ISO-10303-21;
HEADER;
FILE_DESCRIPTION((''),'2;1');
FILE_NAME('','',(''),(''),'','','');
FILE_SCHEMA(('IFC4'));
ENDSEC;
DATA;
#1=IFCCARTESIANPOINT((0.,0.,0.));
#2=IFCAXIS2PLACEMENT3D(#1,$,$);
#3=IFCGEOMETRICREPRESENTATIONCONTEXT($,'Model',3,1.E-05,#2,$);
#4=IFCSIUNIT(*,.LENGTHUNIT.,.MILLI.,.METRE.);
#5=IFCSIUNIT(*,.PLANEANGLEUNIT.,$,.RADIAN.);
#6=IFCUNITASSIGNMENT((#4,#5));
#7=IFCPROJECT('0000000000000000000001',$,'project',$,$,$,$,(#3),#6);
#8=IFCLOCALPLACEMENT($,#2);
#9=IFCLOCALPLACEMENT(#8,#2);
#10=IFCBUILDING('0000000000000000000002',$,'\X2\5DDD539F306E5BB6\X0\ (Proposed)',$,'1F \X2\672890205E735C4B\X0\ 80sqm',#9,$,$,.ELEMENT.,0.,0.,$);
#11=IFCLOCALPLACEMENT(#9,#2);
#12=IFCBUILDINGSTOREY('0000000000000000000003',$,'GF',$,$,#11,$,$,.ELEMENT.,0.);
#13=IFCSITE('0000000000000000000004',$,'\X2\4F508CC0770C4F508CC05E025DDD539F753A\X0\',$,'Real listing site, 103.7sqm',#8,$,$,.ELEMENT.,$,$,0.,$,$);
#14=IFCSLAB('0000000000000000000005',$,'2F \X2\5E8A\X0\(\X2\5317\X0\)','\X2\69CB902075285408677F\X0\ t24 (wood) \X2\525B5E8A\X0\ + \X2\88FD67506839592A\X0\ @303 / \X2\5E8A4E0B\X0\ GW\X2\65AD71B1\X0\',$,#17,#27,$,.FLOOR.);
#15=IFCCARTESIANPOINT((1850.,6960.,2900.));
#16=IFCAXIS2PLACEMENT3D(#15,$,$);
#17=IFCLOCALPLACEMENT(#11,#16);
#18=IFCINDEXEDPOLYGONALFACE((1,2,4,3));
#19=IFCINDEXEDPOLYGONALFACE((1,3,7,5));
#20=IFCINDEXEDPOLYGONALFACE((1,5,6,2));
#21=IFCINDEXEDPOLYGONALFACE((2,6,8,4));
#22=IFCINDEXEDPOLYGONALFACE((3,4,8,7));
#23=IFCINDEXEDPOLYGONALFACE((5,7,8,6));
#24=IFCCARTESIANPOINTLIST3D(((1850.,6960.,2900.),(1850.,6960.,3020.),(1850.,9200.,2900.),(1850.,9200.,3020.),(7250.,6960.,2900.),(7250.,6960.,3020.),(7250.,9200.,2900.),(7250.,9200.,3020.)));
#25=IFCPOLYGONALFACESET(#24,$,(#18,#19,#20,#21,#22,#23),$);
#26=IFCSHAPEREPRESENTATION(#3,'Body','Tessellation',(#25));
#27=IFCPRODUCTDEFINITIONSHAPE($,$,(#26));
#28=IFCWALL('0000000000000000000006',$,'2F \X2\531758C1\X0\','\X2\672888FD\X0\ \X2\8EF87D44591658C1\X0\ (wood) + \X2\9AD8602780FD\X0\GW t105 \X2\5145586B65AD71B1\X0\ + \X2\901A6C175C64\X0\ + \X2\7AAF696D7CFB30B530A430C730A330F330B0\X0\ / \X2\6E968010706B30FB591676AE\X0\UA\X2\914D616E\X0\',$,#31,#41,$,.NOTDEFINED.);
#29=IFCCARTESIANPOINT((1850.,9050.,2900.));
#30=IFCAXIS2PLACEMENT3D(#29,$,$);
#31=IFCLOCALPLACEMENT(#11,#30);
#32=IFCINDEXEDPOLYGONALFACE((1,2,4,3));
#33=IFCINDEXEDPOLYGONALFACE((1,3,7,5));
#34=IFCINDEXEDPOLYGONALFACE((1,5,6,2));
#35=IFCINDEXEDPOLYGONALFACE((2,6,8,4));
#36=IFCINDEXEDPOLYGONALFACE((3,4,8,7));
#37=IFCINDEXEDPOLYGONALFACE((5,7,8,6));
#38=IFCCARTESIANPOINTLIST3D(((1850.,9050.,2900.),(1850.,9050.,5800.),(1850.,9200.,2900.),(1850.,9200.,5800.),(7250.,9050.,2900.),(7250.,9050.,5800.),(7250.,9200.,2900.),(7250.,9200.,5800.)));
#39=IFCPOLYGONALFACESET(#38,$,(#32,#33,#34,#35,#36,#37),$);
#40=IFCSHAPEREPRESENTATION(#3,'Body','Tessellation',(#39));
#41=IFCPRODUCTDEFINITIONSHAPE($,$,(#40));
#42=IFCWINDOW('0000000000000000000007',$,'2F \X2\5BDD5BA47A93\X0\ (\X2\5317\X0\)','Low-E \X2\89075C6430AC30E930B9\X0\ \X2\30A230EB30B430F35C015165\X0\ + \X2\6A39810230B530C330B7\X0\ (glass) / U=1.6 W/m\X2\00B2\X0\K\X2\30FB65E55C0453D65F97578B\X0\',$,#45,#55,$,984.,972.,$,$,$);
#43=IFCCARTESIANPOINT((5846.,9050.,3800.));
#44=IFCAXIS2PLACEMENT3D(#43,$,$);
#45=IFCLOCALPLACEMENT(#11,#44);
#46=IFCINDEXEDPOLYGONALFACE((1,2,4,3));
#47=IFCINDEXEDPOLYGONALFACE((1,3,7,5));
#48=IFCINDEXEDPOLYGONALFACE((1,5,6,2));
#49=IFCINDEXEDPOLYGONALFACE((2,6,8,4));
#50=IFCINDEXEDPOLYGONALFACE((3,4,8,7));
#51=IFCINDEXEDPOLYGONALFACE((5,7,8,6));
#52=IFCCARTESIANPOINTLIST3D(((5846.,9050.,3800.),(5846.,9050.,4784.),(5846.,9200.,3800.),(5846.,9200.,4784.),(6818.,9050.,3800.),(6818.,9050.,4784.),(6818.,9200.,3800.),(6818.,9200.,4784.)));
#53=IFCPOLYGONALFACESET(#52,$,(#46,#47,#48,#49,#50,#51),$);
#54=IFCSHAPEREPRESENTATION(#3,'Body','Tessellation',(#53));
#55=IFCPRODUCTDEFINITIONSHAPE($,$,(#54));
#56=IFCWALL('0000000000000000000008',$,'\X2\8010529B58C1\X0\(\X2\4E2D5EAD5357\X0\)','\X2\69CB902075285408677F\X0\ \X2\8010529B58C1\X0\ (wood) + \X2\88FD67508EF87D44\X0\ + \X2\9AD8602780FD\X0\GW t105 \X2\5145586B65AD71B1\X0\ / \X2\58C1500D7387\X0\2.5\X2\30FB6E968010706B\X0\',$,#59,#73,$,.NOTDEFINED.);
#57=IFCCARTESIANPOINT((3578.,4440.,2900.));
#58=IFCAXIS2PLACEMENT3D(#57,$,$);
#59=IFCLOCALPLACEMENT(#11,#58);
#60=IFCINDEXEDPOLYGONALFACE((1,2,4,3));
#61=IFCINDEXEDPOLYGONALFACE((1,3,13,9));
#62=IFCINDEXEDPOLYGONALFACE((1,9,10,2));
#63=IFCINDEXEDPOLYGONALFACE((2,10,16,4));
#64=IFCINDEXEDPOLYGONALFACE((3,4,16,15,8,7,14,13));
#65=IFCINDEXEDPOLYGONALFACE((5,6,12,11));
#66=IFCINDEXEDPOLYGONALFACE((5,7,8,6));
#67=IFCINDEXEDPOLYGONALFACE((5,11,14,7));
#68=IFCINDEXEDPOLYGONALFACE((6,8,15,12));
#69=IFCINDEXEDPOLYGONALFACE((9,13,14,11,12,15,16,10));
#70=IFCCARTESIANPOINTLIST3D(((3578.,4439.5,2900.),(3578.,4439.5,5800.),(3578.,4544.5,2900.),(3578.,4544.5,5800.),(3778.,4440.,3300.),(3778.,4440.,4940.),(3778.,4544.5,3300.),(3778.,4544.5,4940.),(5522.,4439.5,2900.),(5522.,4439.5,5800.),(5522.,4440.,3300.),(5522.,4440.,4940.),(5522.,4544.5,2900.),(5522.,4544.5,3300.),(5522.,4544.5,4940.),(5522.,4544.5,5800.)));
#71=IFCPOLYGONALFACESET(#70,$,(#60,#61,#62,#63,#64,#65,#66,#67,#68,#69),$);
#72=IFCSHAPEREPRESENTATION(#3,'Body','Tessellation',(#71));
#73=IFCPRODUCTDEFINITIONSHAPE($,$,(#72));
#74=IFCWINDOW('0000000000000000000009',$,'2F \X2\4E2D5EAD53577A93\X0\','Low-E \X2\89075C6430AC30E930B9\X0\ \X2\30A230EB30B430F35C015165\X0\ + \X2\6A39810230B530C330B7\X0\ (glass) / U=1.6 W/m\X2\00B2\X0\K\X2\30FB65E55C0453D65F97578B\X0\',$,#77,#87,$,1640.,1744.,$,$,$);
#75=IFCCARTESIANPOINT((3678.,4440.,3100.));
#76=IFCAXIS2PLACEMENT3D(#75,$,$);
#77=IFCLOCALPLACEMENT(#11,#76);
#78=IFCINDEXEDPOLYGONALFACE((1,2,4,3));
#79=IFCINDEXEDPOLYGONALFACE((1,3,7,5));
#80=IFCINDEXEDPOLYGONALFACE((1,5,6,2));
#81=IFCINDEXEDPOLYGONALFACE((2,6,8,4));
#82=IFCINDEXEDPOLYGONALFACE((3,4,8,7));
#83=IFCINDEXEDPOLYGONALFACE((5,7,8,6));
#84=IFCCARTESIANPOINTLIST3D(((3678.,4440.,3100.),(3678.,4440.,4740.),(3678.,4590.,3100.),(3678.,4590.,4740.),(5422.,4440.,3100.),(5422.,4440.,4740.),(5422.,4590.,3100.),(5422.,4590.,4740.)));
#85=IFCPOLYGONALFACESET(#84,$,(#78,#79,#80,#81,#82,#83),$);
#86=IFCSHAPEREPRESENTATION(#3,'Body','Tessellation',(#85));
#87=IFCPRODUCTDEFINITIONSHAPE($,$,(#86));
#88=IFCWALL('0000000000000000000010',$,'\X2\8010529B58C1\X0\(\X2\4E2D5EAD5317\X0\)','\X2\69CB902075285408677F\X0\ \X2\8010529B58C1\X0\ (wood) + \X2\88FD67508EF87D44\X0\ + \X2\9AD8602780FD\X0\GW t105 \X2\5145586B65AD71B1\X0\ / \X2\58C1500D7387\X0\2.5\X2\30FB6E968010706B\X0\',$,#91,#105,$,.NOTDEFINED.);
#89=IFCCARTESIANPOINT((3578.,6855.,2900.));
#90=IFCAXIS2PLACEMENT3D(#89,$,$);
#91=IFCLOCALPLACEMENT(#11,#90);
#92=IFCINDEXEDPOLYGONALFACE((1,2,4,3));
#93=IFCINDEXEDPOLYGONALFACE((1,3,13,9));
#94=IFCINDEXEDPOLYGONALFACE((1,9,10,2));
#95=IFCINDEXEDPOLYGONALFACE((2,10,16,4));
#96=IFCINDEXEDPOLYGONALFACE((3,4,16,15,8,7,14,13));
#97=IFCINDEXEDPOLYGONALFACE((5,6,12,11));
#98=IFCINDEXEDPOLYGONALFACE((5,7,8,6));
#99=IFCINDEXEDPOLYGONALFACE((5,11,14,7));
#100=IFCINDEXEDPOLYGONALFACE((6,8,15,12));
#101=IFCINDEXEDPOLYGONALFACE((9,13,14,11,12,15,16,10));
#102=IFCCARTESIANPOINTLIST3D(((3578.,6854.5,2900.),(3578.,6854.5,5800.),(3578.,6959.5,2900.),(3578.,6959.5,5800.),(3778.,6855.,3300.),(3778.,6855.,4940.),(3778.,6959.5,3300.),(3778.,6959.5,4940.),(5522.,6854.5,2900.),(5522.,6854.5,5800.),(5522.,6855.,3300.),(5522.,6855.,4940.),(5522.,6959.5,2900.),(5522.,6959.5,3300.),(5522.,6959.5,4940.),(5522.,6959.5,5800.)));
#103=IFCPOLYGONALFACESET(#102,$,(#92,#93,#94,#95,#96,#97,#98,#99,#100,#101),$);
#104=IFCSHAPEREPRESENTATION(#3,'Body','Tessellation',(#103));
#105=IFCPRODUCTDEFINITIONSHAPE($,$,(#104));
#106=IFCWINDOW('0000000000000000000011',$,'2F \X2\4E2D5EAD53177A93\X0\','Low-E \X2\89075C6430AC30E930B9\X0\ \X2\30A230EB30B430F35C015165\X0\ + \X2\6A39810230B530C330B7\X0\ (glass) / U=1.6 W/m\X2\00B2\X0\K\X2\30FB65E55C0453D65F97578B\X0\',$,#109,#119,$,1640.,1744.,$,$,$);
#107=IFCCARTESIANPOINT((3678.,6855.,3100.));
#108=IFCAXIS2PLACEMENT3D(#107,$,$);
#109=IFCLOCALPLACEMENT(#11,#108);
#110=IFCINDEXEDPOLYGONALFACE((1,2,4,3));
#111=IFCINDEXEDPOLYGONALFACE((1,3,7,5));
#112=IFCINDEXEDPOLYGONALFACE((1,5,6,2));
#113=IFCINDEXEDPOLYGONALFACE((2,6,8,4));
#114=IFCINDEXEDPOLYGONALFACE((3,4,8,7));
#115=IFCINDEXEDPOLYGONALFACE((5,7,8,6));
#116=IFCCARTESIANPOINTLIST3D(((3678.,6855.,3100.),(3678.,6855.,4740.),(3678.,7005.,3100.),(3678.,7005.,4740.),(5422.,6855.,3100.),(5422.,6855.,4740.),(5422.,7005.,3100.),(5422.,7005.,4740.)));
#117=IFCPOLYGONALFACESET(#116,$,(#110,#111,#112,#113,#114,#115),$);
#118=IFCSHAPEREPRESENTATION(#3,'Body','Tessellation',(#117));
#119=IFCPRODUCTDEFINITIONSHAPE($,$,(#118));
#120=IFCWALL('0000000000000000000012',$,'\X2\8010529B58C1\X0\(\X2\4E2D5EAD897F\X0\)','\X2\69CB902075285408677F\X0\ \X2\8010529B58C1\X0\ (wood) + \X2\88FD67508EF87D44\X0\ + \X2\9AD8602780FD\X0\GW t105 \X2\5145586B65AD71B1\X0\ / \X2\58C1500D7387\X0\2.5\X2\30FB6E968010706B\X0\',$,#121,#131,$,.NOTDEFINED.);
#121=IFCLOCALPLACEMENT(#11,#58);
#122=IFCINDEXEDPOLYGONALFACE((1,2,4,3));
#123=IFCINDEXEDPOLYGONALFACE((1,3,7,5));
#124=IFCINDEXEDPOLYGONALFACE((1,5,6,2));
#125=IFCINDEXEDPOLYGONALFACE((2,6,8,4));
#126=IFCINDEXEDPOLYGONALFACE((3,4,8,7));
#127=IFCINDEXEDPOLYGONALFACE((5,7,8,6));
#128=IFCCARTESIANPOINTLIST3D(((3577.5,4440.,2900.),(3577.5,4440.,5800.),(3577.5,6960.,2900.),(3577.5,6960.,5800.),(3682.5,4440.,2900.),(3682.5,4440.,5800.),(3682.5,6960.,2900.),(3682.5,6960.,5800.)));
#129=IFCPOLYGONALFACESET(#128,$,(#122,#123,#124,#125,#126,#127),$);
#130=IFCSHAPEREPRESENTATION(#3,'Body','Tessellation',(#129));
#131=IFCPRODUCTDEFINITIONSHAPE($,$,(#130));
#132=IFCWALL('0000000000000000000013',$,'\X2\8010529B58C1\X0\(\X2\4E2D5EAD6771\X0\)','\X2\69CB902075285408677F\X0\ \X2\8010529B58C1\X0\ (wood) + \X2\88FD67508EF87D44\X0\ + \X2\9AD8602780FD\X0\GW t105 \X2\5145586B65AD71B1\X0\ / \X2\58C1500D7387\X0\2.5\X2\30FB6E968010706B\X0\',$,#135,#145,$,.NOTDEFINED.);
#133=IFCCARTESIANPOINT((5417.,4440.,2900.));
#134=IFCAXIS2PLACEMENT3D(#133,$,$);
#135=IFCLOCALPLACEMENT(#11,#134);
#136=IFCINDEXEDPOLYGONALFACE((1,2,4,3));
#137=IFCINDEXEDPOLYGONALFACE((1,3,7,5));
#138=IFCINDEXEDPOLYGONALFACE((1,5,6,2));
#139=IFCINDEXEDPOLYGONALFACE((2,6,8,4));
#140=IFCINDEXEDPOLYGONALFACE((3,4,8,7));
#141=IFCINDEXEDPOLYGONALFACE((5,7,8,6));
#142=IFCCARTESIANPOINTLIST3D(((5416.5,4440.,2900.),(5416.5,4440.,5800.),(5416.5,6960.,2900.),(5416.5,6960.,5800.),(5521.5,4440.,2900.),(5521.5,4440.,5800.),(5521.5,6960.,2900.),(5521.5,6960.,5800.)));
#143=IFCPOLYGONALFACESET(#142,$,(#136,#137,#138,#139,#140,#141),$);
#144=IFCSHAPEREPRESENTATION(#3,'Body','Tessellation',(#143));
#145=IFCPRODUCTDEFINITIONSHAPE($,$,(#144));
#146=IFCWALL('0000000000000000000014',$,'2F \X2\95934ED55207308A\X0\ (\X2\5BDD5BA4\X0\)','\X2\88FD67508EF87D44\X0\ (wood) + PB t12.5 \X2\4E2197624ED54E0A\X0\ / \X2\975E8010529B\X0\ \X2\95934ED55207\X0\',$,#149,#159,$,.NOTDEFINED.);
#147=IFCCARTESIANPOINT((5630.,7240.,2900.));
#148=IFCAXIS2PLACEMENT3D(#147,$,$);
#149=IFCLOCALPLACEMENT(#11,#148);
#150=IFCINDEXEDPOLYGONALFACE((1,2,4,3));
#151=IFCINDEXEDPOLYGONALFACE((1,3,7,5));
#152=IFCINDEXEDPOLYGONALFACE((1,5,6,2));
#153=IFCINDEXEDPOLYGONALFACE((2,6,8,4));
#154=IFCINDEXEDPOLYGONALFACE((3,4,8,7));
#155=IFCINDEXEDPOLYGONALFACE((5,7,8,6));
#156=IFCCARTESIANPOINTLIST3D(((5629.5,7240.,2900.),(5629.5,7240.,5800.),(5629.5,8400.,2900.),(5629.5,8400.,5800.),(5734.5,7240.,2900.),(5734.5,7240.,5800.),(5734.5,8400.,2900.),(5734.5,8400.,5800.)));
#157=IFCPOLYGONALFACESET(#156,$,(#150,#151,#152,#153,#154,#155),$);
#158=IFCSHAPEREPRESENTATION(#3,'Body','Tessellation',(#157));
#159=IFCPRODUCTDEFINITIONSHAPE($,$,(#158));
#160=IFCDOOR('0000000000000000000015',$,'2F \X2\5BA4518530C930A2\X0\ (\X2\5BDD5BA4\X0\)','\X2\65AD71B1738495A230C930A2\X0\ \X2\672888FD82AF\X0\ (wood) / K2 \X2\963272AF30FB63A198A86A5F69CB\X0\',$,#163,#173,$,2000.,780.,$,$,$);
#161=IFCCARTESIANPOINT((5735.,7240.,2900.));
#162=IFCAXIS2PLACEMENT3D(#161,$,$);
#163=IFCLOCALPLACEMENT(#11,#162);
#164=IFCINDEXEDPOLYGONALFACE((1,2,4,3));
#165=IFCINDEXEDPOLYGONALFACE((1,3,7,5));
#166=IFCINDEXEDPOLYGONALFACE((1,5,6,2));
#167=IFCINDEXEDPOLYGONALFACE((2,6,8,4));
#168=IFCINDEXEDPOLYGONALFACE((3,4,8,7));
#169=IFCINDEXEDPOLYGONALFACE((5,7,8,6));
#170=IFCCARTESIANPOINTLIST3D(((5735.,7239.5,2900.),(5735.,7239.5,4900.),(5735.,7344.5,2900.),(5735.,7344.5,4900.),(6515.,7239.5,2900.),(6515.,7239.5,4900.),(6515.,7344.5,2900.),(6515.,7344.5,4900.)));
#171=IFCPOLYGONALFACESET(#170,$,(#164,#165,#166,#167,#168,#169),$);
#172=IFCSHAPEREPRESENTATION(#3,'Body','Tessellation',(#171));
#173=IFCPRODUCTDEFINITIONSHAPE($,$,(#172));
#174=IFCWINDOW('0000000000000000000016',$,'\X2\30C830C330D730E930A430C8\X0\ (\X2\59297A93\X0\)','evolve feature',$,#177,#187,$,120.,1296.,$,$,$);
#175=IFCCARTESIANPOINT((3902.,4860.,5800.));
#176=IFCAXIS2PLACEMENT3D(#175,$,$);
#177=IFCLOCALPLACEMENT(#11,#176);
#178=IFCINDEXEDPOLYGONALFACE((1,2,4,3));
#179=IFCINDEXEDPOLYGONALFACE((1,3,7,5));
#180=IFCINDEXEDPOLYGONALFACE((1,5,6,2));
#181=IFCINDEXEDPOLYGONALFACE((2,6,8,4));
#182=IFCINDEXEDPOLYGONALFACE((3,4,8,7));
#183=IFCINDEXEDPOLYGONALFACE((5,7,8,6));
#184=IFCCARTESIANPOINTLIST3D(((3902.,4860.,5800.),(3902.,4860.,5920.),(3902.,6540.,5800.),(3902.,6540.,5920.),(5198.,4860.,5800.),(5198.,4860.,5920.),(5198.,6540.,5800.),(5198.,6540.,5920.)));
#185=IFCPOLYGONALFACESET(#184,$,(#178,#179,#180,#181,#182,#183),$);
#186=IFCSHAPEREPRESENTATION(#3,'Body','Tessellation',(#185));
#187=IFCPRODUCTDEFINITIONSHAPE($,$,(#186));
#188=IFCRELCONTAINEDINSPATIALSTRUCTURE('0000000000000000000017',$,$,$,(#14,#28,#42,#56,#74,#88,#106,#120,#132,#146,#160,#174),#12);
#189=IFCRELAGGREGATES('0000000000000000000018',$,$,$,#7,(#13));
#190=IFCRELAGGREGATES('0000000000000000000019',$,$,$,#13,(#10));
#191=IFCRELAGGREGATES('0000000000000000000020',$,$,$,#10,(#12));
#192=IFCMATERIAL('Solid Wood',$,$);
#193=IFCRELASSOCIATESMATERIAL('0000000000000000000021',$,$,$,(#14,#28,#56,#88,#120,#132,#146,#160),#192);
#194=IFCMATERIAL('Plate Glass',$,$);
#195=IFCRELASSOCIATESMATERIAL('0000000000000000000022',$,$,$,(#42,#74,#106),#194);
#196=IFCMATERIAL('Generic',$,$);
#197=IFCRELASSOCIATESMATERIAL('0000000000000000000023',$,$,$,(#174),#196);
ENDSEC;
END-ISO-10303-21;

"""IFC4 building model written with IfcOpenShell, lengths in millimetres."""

from ifc_helpers import new_model, si_unit, frame, frame_2d, origin, place, context, project, spatial, rectangle, extrude, material, element, fill, save


model = new_model("IFC4")

# Units and contexts
model_context = context("Model", 3, precision=1e-05, world=origin())
ifc_project = project(units=[si_unit("LENGTHUNIT", "METRE", prefix="MILLI"), si_unit("PLANEANGLEUNIT", "RADIAN")], contexts=[model_context])

# Site, building, storey
site_placement = place(None, origin())
site = spatial("IfcSite", under=ifc_project, at=site_placement, Name="佐賀県佐賀市川原町", ObjectType="Real listing site, 103.7sqm", CompositionType="ELEMENT", RefElevation=0.0)
building_placement = place(site_placement, origin())
building = spatial("IfcBuilding", under=site, at=building_placement, Name="川原の家 (Proposed)", ObjectType="1F 木造平屋 80sqm", CompositionType="ELEMENT", ElevationOfRefHeight=0.0, ElevationOfTerrain=0.0)
storey_placement = place(building_placement, origin())
storey = spatial("IfcBuildingStorey", under=building, at=storey_placement, Name="GF", CompositionType="ELEMENT", Elevation=0.0)

# Slab
ifc_material_1 = material(Name="Solid Wood")
slab_placement = place(storey_placement, frame((1850.0, 6960.0, 2900.0)))
element("IfcSlab", 1, at=slab_placement, inside=storey, material=ifc_material_1, Name="2F 床(北)", Description="構造用合板 t24 (wood) 剛床 + 製材根太 @303 / 床下 GW断熱", PredefinedType="FLOOR", context=model_context, shape_type="SweptSolid", body=[
    extrude(rectangle(XDim=5400.0, YDim=2240.0, at=frame_2d((2700.0, 1120.0))), frame((1850.0, 6960.0, 2900.0)), (0.0, 0.0, 1.0), 120.0),
])

# Walls, openings, windows
wall_1_placement = place(storey_placement, frame((1850.0, 9050.0, 2900.0)))
wall_1 = element("IfcWall", 2, at=wall_1_placement, inside=storey, material=ifc_material_1, Name="2F 北壁", Description="木製 軸組外壁 (wood) + 高性能GW t105 充填断熱 + 通気層 + 窯業系サイディング / 準耐火・外皮UA配慮", PredefinedType="NOTDEFINED", context=model_context, shape_type="SweptSolid", body=[
    extrude(rectangle(XDim=5400.0, YDim=150.0, at=frame_2d((2700.0, 75.0))), frame((1850.0, 9050.0, 2900.0)), (0.0, 0.0, 1.0), 2900.0),
])
opening_1_placement = place(storey_placement, frame((5846.0, 9050.0, 3800.0)))
opening_1 = element("IfcOpeningElement", 3, at=opening_1_placement, cuts=wall_1, PredefinedType="NOTDEFINED", context=model_context, shape_type="SweptSolid", body=[
    extrude(rectangle(XDim=972.0, YDim=150.0, at=frame_2d((486.0, 75.0))), frame((5846.0, 9050.0, 3800.0)), (0.0, 0.0, 1.0), 984.0),
])
ifc_material_2 = material(Name="Plate Glass")
window_1_placement = place(storey_placement, frame((5846.0, 9050.0, 3800.0)))
window_1 = element("IfcWindow", 4, at=window_1_placement, inside=storey, material=ifc_material_2, Name="2F 寝室窓 (北)", Description="Low-E 複層ガラス アルゴン封入 + 樹脂サッシ (glass) / U=1.6 W/m²K・日射取得型", OverallHeight=984.0, OverallWidth=972.0, context=model_context, shape_type="SweptSolid", body=[
    extrude(rectangle(XDim=972.0, YDim=150.0, at=frame_2d((486.0, 75.0))), frame((5846.0, 9050.0, 3800.0)), (0.0, 0.0, 1.0), 984.0),
])
fill(opening_1, window_1)
wall_2_placement = place(storey_placement, frame((3578.0, 4440.0, 2900.0)))
wall_2 = element("IfcWall", 5, at=wall_2_placement, inside=storey, material=ifc_material_1, Name="耐力壁(中庭南)", Description="構造用合板 耐力壁 (wood) + 製材軸組 + 高性能GW t105 充填断熱 / 壁倍率2.5・準耐火", PredefinedType="NOTDEFINED", context=model_context, shape_type="SweptSolid", body=[
    extrude(rectangle(XDim=1944.0, YDim=105.0, at=frame_2d((972.0, 52.0))), frame((3578.0, 4440.0, 2900.0)), (0.0, 0.0, 1.0), 2900.0),
])
opening_2_placement = place(storey_placement, frame((3678.0, 4440.0, 3100.0)))
opening_2 = element("IfcOpeningElement", 6, at=opening_2_placement, cuts=wall_2, PredefinedType="NOTDEFINED", context=model_context, shape_type="SweptSolid", body=[
    extrude(rectangle(XDim=1744.0, YDim=150.0, at=frame_2d((872.0, 75.0))), frame((3678.0, 4440.0, 3100.0)), (0.0, 0.0, 1.0), 1640.0),
])
window_2_placement = place(storey_placement, frame((3678.0, 4440.0, 3100.0)))
window_2 = element("IfcWindow", 7, at=window_2_placement, inside=storey, material=ifc_material_2, Name="2F 中庭南窓", Description="Low-E 複層ガラス アルゴン封入 + 樹脂サッシ (glass) / U=1.6 W/m²K・日射取得型", OverallHeight=1640.0, OverallWidth=1744.0, context=model_context, shape_type="SweptSolid", body=[
    extrude(rectangle(XDim=1744.0, YDim=150.0, at=frame_2d((872.0, 75.0))), frame((3678.0, 4440.0, 3100.0)), (0.0, 0.0, 1.0), 1640.0),
])
fill(opening_2, window_2)
wall_3_placement = place(storey_placement, frame((3578.0, 6855.0, 2900.0)))
wall_3 = element("IfcWall", 8, at=wall_3_placement, inside=storey, material=ifc_material_1, Name="耐力壁(中庭北)", Description="構造用合板 耐力壁 (wood) + 製材軸組 + 高性能GW t105 充填断熱 / 壁倍率2.5・準耐火", PredefinedType="NOTDEFINED", context=model_context, shape_type="SweptSolid", body=[
    extrude(rectangle(XDim=1944.0, YDim=105.0, at=frame_2d((972.0, 52.0))), frame((3578.0, 6855.0, 2900.0)), (0.0, 0.0, 1.0), 2900.0),
])
opening_3_placement = place(storey_placement, frame((3678.0, 6855.0, 3100.0)))
opening_3 = element("IfcOpeningElement", 9, at=opening_3_placement, cuts=wall_3, PredefinedType="NOTDEFINED", context=model_context, shape_type="SweptSolid", body=[
    extrude(rectangle(XDim=1744.0, YDim=150.0, at=frame_2d((872.0, 75.0))), frame((3678.0, 6855.0, 3100.0)), (0.0, 0.0, 1.0), 1640.0),
])
window_3_placement = place(storey_placement, frame((3678.0, 6855.0, 3100.0)))
window_3 = element("IfcWindow", 10, at=window_3_placement, inside=storey, material=ifc_material_2, Name="2F 中庭北窓", Description="Low-E 複層ガラス アルゴン封入 + 樹脂サッシ (glass) / U=1.6 W/m²K・日射取得型", OverallHeight=1640.0, OverallWidth=1744.0, context=model_context, shape_type="SweptSolid", body=[
    extrude(rectangle(XDim=1744.0, YDim=150.0, at=frame_2d((872.0, 75.0))), frame((3678.0, 6855.0, 3100.0)), (0.0, 0.0, 1.0), 1640.0),
])
fill(opening_3, window_3)

# Walls
wall_4_placement = place(storey_placement, frame((3578.0, 4440.0, 2900.0)))
element("IfcWall", 11, at=wall_4_placement, inside=storey, material=ifc_material_1, Name="耐力壁(中庭西)", Description="構造用合板 耐力壁 (wood) + 製材軸組 + 高性能GW t105 充填断熱 / 壁倍率2.5・準耐火", PredefinedType="NOTDEFINED", context=model_context, shape_type="SweptSolid", body=[
    extrude(rectangle(XDim=105.0, YDim=2520.0, at=frame_2d((52.0, 1260.0))), frame((3578.0, 4440.0, 2900.0)), (0.0, 0.0, 1.0), 2900.0),
])
wall_5_placement = place(storey_placement, frame((5417.0, 4440.0, 2900.0)))
element("IfcWall", 12, at=wall_5_placement, inside=storey, material=ifc_material_1, Name="耐力壁(中庭東)", Description="構造用合板 耐力壁 (wood) + 製材軸組 + 高性能GW t105 充填断熱 / 壁倍率2.5・準耐火", PredefinedType="NOTDEFINED", context=model_context, shape_type="SweptSolid", body=[
    extrude(rectangle(XDim=105.0, YDim=2520.0, at=frame_2d((52.0, 1260.0))), frame((5417.0, 4440.0, 2900.0)), (0.0, 0.0, 1.0), 2900.0),
])
wall_6_placement = place(storey_placement, frame((5630.0, 7240.0, 2900.0)))
element("IfcWall", 13, at=wall_6_placement, inside=storey, material=ifc_material_1, Name="2F 間仕切り (寝室)", Description="製材軸組 (wood) + PB t12.5 両面仕上 / 非耐力 間仕切", PredefinedType="NOTDEFINED", context=model_context, shape_type="SweptSolid", body=[
    extrude(rectangle(XDim=105.0, YDim=1160.0, at=frame_2d((52.0, 580.0))), frame((5630.0, 7240.0, 2900.0)), (0.0, 0.0, 1.0), 2900.0),
])

# Door
door_placement = place(storey_placement, frame((5735.0, 7240.0, 2900.0)))
element("IfcDoor", 14, at=door_placement, inside=storey, material=ifc_material_1, Name="2F 室内ドア (寝室)", Description="断熱玄関ドア 木製芯 (wood) / K2 防犯・採風機構", OverallHeight=2000.0, OverallWidth=780.0, context=model_context, shape_type="SweptSolid", body=[
    extrude(rectangle(XDim=780.0, YDim=105.0, at=frame_2d((390.0, 52.0))), frame((5735.0, 7240.0, 2900.0)), (0.0, 0.0, 1.0), 2000.0),
])

# Window
ifc_material_3 = material(Name="Generic")
window_4_placement = place(storey_placement, frame((3902.0, 4860.0, 5800.0)))
element("IfcWindow", 15, at=window_4_placement, inside=storey, material=ifc_material_3, Name="トップライト (天窓)", Description="evolve feature", OverallHeight=120.0, OverallWidth=1296.0, context=model_context, shape_type="SweptSolid", body=[
    extrude(rectangle(XDim=1296.0, YDim=1680.0, at=frame_2d((648.0, 840.0))), frame((3902.0, 4860.0, 5800.0)), (0.0, 0.0, 1.0), 120.0),
])

save(model, "model.ifc")
